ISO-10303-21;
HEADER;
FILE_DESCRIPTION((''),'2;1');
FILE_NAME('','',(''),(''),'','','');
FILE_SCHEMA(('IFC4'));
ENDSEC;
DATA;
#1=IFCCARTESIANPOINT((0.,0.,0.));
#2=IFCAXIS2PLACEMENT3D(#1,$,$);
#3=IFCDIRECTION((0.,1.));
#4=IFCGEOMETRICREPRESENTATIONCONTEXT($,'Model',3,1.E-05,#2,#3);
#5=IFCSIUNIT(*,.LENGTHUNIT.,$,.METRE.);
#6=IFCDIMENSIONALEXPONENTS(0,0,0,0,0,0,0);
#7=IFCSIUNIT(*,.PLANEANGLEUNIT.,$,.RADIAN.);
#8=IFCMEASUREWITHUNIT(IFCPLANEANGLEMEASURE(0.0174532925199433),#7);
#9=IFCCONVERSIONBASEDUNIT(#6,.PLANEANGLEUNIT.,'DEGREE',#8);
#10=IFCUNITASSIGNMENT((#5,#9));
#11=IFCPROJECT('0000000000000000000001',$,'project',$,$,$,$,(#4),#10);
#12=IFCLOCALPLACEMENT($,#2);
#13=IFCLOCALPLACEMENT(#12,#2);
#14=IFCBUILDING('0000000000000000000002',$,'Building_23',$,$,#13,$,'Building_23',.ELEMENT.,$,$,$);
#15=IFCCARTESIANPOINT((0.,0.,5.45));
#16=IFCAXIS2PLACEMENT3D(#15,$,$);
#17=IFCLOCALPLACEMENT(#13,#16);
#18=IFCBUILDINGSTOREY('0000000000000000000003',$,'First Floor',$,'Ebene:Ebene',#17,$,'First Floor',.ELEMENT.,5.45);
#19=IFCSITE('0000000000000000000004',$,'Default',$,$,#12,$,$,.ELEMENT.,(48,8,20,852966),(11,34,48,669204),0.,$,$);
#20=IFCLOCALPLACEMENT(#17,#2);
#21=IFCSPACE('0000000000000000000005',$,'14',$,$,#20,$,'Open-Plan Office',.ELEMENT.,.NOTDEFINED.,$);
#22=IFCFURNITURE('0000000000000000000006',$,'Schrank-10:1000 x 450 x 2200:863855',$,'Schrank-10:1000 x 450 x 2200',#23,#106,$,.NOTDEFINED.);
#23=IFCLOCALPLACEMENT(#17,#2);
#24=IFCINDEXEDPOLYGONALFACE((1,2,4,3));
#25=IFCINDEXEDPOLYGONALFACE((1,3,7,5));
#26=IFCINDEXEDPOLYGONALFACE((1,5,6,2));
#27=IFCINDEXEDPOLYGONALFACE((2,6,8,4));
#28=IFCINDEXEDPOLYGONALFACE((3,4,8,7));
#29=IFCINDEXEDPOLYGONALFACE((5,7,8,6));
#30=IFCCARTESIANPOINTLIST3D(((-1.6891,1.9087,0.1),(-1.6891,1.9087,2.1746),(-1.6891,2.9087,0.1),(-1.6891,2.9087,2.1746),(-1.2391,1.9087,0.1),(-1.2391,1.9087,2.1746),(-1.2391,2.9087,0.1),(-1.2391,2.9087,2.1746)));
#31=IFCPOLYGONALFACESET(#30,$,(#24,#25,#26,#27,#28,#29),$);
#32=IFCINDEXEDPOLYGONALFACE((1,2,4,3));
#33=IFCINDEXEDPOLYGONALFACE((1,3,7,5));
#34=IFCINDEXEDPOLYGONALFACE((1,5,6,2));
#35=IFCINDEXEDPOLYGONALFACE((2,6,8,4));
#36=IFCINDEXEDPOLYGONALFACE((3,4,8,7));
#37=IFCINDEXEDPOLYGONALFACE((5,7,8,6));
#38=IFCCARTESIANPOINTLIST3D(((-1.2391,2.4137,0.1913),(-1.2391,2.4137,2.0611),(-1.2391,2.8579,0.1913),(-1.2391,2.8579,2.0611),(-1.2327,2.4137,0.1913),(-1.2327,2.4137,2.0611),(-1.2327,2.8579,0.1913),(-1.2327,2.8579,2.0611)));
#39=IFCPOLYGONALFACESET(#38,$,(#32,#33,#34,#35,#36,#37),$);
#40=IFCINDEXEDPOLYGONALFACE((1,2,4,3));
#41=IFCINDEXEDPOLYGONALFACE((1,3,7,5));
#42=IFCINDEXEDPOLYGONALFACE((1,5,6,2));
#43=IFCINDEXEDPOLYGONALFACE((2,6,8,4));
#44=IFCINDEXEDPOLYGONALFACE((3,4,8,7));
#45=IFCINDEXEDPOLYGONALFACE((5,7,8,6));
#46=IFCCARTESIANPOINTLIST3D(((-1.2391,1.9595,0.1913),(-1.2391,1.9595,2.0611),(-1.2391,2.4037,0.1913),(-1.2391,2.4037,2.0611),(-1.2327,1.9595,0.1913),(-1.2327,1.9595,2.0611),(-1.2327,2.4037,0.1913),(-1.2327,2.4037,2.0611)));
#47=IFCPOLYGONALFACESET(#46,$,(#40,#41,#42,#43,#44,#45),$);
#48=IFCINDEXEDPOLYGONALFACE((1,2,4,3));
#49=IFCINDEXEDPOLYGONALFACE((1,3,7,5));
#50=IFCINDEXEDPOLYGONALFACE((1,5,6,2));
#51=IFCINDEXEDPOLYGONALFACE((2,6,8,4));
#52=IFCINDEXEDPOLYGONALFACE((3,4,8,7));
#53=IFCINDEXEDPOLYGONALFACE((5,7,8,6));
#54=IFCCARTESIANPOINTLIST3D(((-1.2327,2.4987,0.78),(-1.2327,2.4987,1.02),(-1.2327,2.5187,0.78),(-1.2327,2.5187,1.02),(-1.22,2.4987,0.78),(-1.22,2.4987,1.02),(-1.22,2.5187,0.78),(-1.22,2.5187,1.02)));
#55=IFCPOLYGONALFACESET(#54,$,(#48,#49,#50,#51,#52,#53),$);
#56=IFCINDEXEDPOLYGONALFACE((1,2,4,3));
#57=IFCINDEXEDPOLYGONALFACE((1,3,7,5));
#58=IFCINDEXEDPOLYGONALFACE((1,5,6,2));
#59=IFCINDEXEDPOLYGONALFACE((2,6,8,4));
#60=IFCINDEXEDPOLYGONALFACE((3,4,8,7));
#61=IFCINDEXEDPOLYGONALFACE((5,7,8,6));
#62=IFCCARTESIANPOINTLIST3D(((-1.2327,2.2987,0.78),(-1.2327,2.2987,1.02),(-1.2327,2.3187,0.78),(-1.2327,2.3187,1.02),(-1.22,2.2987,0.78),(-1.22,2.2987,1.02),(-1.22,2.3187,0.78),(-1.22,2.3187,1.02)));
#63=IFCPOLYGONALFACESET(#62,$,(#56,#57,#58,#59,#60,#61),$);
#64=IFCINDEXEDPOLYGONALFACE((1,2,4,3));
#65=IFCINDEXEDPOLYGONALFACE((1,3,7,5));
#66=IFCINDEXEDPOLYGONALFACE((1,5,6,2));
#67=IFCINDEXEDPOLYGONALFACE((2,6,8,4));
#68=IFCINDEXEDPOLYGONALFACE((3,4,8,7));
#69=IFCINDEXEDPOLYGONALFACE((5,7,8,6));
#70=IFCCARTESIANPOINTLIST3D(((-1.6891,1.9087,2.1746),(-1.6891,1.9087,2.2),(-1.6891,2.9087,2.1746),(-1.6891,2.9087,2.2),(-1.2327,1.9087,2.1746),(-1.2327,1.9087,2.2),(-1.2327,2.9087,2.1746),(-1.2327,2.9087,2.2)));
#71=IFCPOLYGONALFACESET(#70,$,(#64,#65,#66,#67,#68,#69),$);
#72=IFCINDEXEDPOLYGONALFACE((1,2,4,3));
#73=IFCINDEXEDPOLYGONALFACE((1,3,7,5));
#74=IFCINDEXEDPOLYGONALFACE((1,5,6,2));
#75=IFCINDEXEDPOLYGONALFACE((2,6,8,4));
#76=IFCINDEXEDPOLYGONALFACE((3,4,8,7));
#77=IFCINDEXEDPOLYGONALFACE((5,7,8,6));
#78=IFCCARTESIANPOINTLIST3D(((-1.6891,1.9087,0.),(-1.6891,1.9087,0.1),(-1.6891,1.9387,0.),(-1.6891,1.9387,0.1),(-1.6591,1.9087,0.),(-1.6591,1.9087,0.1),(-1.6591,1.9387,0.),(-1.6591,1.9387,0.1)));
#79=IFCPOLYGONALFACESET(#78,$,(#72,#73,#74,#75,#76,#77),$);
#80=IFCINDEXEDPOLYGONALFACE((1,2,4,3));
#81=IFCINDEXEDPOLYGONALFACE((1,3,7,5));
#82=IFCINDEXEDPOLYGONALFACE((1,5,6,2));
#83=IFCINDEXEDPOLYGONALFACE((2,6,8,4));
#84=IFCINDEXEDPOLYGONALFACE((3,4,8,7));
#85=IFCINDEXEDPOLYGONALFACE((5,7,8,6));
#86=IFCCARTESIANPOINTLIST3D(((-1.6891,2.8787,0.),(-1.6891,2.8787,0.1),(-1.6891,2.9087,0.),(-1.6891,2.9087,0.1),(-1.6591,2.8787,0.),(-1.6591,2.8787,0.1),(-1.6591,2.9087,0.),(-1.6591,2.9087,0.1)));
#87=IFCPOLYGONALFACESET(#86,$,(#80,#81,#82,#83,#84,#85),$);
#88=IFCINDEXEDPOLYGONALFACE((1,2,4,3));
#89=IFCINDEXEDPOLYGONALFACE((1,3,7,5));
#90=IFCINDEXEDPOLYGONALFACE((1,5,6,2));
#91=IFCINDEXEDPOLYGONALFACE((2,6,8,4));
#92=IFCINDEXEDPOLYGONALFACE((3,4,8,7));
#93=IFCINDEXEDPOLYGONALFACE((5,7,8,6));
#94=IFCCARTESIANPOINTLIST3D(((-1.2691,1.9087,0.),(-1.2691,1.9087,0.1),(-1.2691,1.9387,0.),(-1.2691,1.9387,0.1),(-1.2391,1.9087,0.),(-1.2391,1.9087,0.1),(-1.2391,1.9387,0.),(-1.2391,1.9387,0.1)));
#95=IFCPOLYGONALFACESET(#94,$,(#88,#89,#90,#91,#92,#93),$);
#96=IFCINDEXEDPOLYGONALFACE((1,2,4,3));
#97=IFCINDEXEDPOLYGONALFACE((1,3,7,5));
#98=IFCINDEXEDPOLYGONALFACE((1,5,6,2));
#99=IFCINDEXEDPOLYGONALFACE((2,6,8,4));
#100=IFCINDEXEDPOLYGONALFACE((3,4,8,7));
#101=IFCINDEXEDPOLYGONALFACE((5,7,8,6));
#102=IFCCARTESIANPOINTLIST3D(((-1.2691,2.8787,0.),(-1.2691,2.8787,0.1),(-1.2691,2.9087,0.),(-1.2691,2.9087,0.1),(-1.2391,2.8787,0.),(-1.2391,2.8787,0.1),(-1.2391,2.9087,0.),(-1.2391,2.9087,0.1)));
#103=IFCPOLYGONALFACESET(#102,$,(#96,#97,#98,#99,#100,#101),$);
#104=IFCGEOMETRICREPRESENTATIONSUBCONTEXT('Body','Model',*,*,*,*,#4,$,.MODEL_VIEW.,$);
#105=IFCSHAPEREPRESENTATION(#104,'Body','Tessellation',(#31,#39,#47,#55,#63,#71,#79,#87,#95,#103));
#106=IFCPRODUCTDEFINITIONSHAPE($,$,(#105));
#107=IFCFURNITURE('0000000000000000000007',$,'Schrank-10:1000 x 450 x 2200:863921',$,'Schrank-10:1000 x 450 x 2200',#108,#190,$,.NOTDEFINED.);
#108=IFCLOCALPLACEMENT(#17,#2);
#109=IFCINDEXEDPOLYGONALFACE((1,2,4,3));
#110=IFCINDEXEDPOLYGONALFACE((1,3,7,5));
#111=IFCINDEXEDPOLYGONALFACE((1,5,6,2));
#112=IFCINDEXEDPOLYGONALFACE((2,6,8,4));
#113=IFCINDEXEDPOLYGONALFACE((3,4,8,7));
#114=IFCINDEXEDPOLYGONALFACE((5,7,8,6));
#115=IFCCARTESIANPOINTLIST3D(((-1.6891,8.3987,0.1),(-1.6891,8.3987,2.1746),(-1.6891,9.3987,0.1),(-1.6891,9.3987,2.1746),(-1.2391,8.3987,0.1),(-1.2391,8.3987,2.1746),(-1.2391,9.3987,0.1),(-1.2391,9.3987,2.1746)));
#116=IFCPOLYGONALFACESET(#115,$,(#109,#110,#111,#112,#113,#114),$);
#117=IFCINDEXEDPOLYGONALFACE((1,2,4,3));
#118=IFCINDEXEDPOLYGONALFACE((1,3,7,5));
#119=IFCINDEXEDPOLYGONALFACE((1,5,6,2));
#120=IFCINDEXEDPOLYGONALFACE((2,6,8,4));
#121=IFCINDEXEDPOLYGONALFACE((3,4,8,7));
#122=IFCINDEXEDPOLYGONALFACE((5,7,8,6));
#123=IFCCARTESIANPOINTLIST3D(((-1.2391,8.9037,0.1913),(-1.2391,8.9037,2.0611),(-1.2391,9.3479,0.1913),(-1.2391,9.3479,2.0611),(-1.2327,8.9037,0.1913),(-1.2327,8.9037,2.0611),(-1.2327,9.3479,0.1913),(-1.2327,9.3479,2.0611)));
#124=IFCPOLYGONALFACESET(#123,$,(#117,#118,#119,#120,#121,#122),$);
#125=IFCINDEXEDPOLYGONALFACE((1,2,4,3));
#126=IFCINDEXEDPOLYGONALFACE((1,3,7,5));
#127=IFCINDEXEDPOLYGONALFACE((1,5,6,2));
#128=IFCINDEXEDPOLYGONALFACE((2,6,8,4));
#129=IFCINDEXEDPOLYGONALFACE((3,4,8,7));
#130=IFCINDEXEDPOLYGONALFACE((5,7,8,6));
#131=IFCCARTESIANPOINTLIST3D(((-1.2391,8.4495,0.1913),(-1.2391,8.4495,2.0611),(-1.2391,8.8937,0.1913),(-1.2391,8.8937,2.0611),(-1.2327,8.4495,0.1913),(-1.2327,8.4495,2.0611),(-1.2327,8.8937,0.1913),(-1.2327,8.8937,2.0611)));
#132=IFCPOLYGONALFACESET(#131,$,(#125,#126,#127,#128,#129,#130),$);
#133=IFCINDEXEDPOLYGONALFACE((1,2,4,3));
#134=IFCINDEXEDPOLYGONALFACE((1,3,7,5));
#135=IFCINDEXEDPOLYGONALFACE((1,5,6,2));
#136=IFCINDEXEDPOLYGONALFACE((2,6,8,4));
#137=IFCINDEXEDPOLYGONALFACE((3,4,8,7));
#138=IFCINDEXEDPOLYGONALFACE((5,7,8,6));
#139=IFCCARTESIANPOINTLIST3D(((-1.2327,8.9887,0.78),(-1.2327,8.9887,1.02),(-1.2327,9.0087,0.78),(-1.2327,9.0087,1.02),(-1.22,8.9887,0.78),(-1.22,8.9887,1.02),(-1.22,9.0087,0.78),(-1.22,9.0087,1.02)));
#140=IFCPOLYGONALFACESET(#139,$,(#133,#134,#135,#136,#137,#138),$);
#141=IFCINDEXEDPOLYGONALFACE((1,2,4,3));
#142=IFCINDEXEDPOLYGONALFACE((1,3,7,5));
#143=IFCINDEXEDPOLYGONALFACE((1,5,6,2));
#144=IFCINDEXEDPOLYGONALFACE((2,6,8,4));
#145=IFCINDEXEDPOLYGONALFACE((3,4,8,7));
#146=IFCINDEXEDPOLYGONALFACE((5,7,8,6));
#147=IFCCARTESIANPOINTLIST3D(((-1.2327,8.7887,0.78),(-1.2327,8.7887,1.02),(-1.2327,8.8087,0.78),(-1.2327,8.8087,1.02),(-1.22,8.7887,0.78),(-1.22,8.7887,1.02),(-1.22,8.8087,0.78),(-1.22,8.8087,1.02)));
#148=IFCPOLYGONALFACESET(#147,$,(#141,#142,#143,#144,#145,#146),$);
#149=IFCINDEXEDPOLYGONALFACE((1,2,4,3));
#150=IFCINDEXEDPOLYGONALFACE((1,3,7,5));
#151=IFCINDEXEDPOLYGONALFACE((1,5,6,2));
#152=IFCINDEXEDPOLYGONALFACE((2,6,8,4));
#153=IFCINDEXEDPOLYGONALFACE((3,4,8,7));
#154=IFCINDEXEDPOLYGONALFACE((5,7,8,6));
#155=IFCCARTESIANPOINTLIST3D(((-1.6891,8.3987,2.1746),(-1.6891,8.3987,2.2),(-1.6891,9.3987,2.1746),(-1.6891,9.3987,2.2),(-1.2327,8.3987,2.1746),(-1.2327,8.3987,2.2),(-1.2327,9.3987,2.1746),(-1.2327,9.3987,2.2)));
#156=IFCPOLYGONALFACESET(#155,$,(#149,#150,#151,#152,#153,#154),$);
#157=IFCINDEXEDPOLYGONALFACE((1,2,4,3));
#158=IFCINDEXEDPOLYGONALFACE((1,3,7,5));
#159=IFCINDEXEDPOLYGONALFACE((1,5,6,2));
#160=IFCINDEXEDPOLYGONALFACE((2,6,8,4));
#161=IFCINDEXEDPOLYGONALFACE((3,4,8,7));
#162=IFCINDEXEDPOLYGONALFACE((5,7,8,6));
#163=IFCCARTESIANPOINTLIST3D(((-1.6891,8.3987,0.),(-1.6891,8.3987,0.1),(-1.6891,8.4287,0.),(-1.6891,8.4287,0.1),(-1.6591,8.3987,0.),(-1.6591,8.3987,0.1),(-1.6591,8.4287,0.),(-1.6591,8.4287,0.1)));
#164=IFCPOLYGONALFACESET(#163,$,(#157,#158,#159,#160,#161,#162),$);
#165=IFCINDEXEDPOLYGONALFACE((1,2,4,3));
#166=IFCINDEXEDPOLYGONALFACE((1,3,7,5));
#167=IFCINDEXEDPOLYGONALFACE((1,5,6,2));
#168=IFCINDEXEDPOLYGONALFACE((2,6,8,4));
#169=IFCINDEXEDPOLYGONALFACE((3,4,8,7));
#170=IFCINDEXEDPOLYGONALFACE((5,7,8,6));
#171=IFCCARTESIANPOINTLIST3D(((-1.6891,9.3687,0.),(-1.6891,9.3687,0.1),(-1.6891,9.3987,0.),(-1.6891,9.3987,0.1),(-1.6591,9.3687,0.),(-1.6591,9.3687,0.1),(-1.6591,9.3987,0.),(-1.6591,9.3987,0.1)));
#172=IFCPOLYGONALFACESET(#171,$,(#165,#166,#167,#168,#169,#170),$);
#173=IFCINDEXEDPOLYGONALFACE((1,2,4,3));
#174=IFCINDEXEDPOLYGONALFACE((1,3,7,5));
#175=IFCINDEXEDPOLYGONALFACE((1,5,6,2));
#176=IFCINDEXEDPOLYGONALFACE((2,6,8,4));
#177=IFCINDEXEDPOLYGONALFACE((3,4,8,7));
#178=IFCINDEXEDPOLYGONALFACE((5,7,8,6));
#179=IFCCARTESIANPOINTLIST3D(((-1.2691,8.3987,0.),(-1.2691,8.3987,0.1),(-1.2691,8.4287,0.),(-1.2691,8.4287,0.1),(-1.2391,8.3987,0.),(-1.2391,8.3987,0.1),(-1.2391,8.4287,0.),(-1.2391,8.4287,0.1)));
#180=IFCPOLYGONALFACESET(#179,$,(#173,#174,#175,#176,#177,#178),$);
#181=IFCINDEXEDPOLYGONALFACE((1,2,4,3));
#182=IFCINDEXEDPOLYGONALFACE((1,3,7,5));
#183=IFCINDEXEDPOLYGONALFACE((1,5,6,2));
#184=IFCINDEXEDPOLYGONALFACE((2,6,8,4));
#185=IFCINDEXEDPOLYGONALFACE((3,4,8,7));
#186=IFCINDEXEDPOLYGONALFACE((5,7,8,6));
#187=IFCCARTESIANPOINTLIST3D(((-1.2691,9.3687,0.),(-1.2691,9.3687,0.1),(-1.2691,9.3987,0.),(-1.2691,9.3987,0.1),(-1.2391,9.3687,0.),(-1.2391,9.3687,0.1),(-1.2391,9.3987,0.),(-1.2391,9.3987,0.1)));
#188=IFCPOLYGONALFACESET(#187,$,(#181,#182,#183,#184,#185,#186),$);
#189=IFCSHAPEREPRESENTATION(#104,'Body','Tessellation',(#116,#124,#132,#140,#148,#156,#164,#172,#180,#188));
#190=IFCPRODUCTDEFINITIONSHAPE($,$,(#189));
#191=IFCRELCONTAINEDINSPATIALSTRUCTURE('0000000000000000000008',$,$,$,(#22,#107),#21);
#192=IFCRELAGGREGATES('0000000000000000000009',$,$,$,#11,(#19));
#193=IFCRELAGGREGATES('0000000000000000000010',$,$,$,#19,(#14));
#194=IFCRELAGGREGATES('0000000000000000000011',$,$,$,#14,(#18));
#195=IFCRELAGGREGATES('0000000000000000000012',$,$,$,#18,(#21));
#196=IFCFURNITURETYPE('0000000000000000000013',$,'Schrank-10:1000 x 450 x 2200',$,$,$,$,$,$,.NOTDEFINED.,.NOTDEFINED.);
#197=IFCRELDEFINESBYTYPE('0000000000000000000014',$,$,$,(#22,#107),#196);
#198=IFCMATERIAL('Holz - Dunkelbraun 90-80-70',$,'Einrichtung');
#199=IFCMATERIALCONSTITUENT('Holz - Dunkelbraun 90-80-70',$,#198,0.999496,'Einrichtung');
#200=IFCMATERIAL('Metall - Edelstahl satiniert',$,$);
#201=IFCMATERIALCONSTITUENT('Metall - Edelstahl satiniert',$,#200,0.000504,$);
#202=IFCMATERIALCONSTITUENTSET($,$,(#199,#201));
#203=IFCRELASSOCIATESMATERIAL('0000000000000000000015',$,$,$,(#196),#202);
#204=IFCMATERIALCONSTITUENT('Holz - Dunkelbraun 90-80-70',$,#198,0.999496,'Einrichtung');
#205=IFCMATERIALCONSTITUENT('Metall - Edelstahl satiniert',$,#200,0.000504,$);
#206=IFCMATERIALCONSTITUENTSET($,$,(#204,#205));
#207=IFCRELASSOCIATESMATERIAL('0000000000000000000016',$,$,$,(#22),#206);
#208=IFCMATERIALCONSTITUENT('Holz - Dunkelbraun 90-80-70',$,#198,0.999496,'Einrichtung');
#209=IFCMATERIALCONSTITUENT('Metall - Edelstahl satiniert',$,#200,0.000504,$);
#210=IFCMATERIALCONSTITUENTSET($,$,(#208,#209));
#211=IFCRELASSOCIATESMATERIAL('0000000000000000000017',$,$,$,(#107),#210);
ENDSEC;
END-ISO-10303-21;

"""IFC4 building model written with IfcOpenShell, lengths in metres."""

from ifc_helpers import new_model, entity, si_unit, converted_unit, direction, frame, origin, place, context, subcontext, project, spatial, indexed_curve, outline, extrude, source, transform, mapped, material, constituent, constituent_set, type_object, type_shapes, element, save


model = new_model("IFC4")

# Units and contexts
model_context = context("Model", 3, precision=1e-05, world=origin(), true_north=direction((0.0, 1.0)))
body_context = subcontext(model_context, "Body", "Model", "MODEL_VIEW")
ifc_project = project(units=[si_unit("LENGTHUNIT", "METRE"), converted_unit("PLANEANGLEUNIT", "DEGREE", entity("IfcPlaneAngleMeasure", 0.0174532925199433), si_unit("PLANEANGLEUNIT", "RADIAN"), dimensions=[0, 0, 0, 0, 0, 0, 0])], contexts=[model_context])

# Site, building, storey
site_placement = place(None, origin())
site = spatial("IfcSite", under=ifc_project, at=site_placement, Name="Default", CompositionType="ELEMENT", RefLatitude=(48, 8, 20, 852966), RefLongitude=(11, 34, 48, 669204), RefElevation=0.0)
building_placement = place(site_placement, origin())
building = spatial("IfcBuilding", under=site, at=building_placement, Name="Building_23", LongName="Building_23", CompositionType="ELEMENT")
storey_placement = place(building_placement, frame((0.0, 0.0, 5.45)))
storey = spatial("IfcBuildingStorey", under=building, at=storey_placement, Name="First Floor", ObjectType="Ebene:Ebene", LongName="First Floor", CompositionType="ELEMENT", Elevation=5.45)

# Shared definitions
ifc_material_1 = material(Name="Holz - Dunkelbraun 90-80-70", Category="Einrichtung")
ifc_material_2 = material(Name="Metall - Edelstahl satiniert")
ifc_constituent_1 = constituent(ifc_material_1, Name="Holz - Dunkelbraun 90-80-70", Category="Einrichtung", fraction=0.999496)
ifc_constituent_2 = constituent(ifc_material_2, Name="Metall - Edelstahl satiniert", fraction=0.000504)
ifc_constituent_set_1 = constituent_set(constituents=[ifc_constituent_1, ifc_constituent_2])
furniture_type = type_object("IfcFurnitureType", Name="Schrank-10:1000 x 450 x 2200", AssemblyPlace="NOTDEFINED", PredefinedType="NOTDEFINED", material=ifc_constituent_set_1)
shared_shape_1 = source(origin(), body_context, "Body", "SweptSolid", [
    extrude(outline(indexed_curve([(-0.225, -0.5), (0.225, -0.5), (0.225, 0.5), (-0.225, 0.5), (-0.225, -0.5)], self_intersect=False)), frame((-0.2692, -0.3632, 0.1), z_axis=(0.0, 0.0, 1.0), x_axis=(0.0, 1.0, 0.0)), (0.0, 0.0, 1.0), 2.0746),
    extrude(outline(indexed_curve([(-0.0032, -0.2221), (0.0032, -0.2221), (0.0032, 0.2221), (-0.0032, 0.2221), (-0.0032, -0.2221)], self_intersect=False)), frame((-0.0421, -0.5913, 0.1913), z_axis=(0.0, 0.0, 1.0), x_axis=(0.0, 1.0, 0.0)), (0.0, 0.0, 1.0), 1.8698),
    extrude(outline(indexed_curve([(-0.0032, -0.2221), (0.0032, -0.2221), (0.0032, 0.2221), (-0.0032, 0.2221), (-0.0032, -0.2221)], self_intersect=False)), frame((-0.4963, -0.5913, 0.1913), z_axis=(0.0, 0.0, 1.0), x_axis=(0.0, 1.0, 0.0)), (0.0, 0.0, 1.0), 1.8698),
    extrude(outline(indexed_curve([(-0.0063, -0.01), (0.0063, -0.01), (0.0063, 0.01), (-0.0063, 0.01), (-0.0063, -0.01)], self_intersect=False)), frame((-0.1692, -0.6009, 0.78), z_axis=(0.0, 0.0, 1.0), x_axis=(0.0, 1.0, 0.0)), (0.0, 0.0, 1.0), 0.24),
    extrude(outline(indexed_curve([(-0.0063, -0.01), (0.0063, -0.01), (0.0063, 0.01), (-0.0063, 0.01), (-0.0063, -0.01)], self_intersect=False)), frame((-0.3692, -0.6009, 0.78), z_axis=(0.0, 0.0, 1.0), x_axis=(0.0, 1.0, 0.0)), (0.0, 0.0, 1.0), 0.24),
    extrude(outline(indexed_curve([(-0.5, -0.2282), (0.5, -0.2282), (0.5, 0.2282), (-0.5, 0.2282), (-0.5, -0.2282)], self_intersect=False)), frame((-0.2692, -0.3663, 2.1746), z_axis=(0.0, 0.0, 1.0), x_axis=(-1.0, 0.0, 0.0)), (0.0, 0.0, 1.0), 0.0254),
    extrude(outline(indexed_curve([(-0.015, -0.015), (0.015, -0.015), (0.015, 0.015), (-0.015, 0.015), (-0.015, -0.015)], self_intersect=False)), frame((-0.7542, -0.1532, 0.0), z_axis=(0.0, 0.0, 1.0), x_axis=(-1.0, 0.0, 0.0)), (0.0, 0.0, 1.0), 0.1),
    extrude(outline(indexed_curve([(-0.015, -0.015), (0.015, -0.015), (0.015, 0.015), (-0.015, 0.015), (-0.015, -0.015)], self_intersect=False)), frame((0.2158, -0.1532, 0.0), z_axis=(0.0, 0.0, 1.0), x_axis=(0.0, -1.0, 0.0)), (0.0, 0.0, 1.0), 0.1),
    extrude(outline(indexed_curve([(-0.015, -0.015), (0.015, -0.015), (0.015, 0.015), (-0.015, 0.015), (-0.015, -0.015)], self_intersect=False)), frame((-0.7542, -0.5732, 0.0), z_axis=(0.0, 0.0, 1.0), x_axis=(0.0, 1.0, 0.0)), (0.0, 0.0, 1.0), 0.1),
    extrude(outline(indexed_curve([(-0.015, -0.015), (0.015, -0.015), (0.015, 0.015), (-0.015, 0.015), (-0.015, -0.015)], self_intersect=False)), frame((0.2158, -0.5732, 0.0)), (0.0, 0.0, 1.0), 0.1),
])
type_shapes(furniture_type, [shared_shape_1])

# Shared definitions
space_1_placement = place(storey_placement, origin())
space_1 = spatial("IfcSpace", under=storey, at=space_1_placement, Name="14", LongName="Open-Plan Office", CompositionType="ELEMENT", PredefinedType="NOTDEFINED")

# Furniture
ifc_constituent_3 = constituent(ifc_material_1, Name="Holz - Dunkelbraun 90-80-70", Category="Einrichtung", fraction=0.999496)
ifc_constituent_4 = constituent(ifc_material_2, Name="Metall - Edelstahl satiniert", fraction=0.000504)
ifc_constituent_set_2 = constituent_set(constituents=[ifc_constituent_3, ifc_constituent_4])
furniture_1_placement = place(space_1_placement, frame((-1.8272, 2.6779, 0.0), z_axis=(0.0, 0.0, 1.0), x_axis=(0.0, 1.0, 0.0)))
element("IfcFurniture", 1, at=furniture_1_placement, inside=space_1, type_object=furniture_type, material=ifc_constituent_set_2, Name="Schrank-10:1000 x 450 x 2200:863855", ObjectType="Schrank-10:1000 x 450 x 2200", PredefinedType="NOTDEFINED", context=body_context, shape_type="MappedRepresentation", body=[
    mapped(shared_shape_1, transform((0.0, 0.0, 0.0), scale=1.0)),
])
ifc_constituent_5 = constituent(ifc_material_1, Name="Holz - Dunkelbraun 90-80-70", Category="Einrichtung", fraction=0.999496)
ifc_constituent_6 = constituent(ifc_material_2, Name="Metall - Edelstahl satiniert", fraction=0.000504)
ifc_constituent_set_3 = constituent_set(constituents=[ifc_constituent_5, ifc_constituent_6])
furniture_2_placement = place(space_1_placement, frame((-1.8272, 9.1679, 0.0), z_axis=(0.0, 0.0, 1.0), x_axis=(0.0, 1.0, 0.0)))
element("IfcFurniture", 2, at=furniture_2_placement, inside=space_1, type_object=furniture_type, material=ifc_constituent_set_3, Name="Schrank-10:1000 x 450 x 2200:863921", ObjectType="Schrank-10:1000 x 450 x 2200", PredefinedType="NOTDEFINED", context=body_context, shape_type="MappedRepresentation", body=[
    mapped(shared_shape_1, transform((0.0, 0.0, 0.0), scale=1.0)),
])

save(model, "model.ifc")
